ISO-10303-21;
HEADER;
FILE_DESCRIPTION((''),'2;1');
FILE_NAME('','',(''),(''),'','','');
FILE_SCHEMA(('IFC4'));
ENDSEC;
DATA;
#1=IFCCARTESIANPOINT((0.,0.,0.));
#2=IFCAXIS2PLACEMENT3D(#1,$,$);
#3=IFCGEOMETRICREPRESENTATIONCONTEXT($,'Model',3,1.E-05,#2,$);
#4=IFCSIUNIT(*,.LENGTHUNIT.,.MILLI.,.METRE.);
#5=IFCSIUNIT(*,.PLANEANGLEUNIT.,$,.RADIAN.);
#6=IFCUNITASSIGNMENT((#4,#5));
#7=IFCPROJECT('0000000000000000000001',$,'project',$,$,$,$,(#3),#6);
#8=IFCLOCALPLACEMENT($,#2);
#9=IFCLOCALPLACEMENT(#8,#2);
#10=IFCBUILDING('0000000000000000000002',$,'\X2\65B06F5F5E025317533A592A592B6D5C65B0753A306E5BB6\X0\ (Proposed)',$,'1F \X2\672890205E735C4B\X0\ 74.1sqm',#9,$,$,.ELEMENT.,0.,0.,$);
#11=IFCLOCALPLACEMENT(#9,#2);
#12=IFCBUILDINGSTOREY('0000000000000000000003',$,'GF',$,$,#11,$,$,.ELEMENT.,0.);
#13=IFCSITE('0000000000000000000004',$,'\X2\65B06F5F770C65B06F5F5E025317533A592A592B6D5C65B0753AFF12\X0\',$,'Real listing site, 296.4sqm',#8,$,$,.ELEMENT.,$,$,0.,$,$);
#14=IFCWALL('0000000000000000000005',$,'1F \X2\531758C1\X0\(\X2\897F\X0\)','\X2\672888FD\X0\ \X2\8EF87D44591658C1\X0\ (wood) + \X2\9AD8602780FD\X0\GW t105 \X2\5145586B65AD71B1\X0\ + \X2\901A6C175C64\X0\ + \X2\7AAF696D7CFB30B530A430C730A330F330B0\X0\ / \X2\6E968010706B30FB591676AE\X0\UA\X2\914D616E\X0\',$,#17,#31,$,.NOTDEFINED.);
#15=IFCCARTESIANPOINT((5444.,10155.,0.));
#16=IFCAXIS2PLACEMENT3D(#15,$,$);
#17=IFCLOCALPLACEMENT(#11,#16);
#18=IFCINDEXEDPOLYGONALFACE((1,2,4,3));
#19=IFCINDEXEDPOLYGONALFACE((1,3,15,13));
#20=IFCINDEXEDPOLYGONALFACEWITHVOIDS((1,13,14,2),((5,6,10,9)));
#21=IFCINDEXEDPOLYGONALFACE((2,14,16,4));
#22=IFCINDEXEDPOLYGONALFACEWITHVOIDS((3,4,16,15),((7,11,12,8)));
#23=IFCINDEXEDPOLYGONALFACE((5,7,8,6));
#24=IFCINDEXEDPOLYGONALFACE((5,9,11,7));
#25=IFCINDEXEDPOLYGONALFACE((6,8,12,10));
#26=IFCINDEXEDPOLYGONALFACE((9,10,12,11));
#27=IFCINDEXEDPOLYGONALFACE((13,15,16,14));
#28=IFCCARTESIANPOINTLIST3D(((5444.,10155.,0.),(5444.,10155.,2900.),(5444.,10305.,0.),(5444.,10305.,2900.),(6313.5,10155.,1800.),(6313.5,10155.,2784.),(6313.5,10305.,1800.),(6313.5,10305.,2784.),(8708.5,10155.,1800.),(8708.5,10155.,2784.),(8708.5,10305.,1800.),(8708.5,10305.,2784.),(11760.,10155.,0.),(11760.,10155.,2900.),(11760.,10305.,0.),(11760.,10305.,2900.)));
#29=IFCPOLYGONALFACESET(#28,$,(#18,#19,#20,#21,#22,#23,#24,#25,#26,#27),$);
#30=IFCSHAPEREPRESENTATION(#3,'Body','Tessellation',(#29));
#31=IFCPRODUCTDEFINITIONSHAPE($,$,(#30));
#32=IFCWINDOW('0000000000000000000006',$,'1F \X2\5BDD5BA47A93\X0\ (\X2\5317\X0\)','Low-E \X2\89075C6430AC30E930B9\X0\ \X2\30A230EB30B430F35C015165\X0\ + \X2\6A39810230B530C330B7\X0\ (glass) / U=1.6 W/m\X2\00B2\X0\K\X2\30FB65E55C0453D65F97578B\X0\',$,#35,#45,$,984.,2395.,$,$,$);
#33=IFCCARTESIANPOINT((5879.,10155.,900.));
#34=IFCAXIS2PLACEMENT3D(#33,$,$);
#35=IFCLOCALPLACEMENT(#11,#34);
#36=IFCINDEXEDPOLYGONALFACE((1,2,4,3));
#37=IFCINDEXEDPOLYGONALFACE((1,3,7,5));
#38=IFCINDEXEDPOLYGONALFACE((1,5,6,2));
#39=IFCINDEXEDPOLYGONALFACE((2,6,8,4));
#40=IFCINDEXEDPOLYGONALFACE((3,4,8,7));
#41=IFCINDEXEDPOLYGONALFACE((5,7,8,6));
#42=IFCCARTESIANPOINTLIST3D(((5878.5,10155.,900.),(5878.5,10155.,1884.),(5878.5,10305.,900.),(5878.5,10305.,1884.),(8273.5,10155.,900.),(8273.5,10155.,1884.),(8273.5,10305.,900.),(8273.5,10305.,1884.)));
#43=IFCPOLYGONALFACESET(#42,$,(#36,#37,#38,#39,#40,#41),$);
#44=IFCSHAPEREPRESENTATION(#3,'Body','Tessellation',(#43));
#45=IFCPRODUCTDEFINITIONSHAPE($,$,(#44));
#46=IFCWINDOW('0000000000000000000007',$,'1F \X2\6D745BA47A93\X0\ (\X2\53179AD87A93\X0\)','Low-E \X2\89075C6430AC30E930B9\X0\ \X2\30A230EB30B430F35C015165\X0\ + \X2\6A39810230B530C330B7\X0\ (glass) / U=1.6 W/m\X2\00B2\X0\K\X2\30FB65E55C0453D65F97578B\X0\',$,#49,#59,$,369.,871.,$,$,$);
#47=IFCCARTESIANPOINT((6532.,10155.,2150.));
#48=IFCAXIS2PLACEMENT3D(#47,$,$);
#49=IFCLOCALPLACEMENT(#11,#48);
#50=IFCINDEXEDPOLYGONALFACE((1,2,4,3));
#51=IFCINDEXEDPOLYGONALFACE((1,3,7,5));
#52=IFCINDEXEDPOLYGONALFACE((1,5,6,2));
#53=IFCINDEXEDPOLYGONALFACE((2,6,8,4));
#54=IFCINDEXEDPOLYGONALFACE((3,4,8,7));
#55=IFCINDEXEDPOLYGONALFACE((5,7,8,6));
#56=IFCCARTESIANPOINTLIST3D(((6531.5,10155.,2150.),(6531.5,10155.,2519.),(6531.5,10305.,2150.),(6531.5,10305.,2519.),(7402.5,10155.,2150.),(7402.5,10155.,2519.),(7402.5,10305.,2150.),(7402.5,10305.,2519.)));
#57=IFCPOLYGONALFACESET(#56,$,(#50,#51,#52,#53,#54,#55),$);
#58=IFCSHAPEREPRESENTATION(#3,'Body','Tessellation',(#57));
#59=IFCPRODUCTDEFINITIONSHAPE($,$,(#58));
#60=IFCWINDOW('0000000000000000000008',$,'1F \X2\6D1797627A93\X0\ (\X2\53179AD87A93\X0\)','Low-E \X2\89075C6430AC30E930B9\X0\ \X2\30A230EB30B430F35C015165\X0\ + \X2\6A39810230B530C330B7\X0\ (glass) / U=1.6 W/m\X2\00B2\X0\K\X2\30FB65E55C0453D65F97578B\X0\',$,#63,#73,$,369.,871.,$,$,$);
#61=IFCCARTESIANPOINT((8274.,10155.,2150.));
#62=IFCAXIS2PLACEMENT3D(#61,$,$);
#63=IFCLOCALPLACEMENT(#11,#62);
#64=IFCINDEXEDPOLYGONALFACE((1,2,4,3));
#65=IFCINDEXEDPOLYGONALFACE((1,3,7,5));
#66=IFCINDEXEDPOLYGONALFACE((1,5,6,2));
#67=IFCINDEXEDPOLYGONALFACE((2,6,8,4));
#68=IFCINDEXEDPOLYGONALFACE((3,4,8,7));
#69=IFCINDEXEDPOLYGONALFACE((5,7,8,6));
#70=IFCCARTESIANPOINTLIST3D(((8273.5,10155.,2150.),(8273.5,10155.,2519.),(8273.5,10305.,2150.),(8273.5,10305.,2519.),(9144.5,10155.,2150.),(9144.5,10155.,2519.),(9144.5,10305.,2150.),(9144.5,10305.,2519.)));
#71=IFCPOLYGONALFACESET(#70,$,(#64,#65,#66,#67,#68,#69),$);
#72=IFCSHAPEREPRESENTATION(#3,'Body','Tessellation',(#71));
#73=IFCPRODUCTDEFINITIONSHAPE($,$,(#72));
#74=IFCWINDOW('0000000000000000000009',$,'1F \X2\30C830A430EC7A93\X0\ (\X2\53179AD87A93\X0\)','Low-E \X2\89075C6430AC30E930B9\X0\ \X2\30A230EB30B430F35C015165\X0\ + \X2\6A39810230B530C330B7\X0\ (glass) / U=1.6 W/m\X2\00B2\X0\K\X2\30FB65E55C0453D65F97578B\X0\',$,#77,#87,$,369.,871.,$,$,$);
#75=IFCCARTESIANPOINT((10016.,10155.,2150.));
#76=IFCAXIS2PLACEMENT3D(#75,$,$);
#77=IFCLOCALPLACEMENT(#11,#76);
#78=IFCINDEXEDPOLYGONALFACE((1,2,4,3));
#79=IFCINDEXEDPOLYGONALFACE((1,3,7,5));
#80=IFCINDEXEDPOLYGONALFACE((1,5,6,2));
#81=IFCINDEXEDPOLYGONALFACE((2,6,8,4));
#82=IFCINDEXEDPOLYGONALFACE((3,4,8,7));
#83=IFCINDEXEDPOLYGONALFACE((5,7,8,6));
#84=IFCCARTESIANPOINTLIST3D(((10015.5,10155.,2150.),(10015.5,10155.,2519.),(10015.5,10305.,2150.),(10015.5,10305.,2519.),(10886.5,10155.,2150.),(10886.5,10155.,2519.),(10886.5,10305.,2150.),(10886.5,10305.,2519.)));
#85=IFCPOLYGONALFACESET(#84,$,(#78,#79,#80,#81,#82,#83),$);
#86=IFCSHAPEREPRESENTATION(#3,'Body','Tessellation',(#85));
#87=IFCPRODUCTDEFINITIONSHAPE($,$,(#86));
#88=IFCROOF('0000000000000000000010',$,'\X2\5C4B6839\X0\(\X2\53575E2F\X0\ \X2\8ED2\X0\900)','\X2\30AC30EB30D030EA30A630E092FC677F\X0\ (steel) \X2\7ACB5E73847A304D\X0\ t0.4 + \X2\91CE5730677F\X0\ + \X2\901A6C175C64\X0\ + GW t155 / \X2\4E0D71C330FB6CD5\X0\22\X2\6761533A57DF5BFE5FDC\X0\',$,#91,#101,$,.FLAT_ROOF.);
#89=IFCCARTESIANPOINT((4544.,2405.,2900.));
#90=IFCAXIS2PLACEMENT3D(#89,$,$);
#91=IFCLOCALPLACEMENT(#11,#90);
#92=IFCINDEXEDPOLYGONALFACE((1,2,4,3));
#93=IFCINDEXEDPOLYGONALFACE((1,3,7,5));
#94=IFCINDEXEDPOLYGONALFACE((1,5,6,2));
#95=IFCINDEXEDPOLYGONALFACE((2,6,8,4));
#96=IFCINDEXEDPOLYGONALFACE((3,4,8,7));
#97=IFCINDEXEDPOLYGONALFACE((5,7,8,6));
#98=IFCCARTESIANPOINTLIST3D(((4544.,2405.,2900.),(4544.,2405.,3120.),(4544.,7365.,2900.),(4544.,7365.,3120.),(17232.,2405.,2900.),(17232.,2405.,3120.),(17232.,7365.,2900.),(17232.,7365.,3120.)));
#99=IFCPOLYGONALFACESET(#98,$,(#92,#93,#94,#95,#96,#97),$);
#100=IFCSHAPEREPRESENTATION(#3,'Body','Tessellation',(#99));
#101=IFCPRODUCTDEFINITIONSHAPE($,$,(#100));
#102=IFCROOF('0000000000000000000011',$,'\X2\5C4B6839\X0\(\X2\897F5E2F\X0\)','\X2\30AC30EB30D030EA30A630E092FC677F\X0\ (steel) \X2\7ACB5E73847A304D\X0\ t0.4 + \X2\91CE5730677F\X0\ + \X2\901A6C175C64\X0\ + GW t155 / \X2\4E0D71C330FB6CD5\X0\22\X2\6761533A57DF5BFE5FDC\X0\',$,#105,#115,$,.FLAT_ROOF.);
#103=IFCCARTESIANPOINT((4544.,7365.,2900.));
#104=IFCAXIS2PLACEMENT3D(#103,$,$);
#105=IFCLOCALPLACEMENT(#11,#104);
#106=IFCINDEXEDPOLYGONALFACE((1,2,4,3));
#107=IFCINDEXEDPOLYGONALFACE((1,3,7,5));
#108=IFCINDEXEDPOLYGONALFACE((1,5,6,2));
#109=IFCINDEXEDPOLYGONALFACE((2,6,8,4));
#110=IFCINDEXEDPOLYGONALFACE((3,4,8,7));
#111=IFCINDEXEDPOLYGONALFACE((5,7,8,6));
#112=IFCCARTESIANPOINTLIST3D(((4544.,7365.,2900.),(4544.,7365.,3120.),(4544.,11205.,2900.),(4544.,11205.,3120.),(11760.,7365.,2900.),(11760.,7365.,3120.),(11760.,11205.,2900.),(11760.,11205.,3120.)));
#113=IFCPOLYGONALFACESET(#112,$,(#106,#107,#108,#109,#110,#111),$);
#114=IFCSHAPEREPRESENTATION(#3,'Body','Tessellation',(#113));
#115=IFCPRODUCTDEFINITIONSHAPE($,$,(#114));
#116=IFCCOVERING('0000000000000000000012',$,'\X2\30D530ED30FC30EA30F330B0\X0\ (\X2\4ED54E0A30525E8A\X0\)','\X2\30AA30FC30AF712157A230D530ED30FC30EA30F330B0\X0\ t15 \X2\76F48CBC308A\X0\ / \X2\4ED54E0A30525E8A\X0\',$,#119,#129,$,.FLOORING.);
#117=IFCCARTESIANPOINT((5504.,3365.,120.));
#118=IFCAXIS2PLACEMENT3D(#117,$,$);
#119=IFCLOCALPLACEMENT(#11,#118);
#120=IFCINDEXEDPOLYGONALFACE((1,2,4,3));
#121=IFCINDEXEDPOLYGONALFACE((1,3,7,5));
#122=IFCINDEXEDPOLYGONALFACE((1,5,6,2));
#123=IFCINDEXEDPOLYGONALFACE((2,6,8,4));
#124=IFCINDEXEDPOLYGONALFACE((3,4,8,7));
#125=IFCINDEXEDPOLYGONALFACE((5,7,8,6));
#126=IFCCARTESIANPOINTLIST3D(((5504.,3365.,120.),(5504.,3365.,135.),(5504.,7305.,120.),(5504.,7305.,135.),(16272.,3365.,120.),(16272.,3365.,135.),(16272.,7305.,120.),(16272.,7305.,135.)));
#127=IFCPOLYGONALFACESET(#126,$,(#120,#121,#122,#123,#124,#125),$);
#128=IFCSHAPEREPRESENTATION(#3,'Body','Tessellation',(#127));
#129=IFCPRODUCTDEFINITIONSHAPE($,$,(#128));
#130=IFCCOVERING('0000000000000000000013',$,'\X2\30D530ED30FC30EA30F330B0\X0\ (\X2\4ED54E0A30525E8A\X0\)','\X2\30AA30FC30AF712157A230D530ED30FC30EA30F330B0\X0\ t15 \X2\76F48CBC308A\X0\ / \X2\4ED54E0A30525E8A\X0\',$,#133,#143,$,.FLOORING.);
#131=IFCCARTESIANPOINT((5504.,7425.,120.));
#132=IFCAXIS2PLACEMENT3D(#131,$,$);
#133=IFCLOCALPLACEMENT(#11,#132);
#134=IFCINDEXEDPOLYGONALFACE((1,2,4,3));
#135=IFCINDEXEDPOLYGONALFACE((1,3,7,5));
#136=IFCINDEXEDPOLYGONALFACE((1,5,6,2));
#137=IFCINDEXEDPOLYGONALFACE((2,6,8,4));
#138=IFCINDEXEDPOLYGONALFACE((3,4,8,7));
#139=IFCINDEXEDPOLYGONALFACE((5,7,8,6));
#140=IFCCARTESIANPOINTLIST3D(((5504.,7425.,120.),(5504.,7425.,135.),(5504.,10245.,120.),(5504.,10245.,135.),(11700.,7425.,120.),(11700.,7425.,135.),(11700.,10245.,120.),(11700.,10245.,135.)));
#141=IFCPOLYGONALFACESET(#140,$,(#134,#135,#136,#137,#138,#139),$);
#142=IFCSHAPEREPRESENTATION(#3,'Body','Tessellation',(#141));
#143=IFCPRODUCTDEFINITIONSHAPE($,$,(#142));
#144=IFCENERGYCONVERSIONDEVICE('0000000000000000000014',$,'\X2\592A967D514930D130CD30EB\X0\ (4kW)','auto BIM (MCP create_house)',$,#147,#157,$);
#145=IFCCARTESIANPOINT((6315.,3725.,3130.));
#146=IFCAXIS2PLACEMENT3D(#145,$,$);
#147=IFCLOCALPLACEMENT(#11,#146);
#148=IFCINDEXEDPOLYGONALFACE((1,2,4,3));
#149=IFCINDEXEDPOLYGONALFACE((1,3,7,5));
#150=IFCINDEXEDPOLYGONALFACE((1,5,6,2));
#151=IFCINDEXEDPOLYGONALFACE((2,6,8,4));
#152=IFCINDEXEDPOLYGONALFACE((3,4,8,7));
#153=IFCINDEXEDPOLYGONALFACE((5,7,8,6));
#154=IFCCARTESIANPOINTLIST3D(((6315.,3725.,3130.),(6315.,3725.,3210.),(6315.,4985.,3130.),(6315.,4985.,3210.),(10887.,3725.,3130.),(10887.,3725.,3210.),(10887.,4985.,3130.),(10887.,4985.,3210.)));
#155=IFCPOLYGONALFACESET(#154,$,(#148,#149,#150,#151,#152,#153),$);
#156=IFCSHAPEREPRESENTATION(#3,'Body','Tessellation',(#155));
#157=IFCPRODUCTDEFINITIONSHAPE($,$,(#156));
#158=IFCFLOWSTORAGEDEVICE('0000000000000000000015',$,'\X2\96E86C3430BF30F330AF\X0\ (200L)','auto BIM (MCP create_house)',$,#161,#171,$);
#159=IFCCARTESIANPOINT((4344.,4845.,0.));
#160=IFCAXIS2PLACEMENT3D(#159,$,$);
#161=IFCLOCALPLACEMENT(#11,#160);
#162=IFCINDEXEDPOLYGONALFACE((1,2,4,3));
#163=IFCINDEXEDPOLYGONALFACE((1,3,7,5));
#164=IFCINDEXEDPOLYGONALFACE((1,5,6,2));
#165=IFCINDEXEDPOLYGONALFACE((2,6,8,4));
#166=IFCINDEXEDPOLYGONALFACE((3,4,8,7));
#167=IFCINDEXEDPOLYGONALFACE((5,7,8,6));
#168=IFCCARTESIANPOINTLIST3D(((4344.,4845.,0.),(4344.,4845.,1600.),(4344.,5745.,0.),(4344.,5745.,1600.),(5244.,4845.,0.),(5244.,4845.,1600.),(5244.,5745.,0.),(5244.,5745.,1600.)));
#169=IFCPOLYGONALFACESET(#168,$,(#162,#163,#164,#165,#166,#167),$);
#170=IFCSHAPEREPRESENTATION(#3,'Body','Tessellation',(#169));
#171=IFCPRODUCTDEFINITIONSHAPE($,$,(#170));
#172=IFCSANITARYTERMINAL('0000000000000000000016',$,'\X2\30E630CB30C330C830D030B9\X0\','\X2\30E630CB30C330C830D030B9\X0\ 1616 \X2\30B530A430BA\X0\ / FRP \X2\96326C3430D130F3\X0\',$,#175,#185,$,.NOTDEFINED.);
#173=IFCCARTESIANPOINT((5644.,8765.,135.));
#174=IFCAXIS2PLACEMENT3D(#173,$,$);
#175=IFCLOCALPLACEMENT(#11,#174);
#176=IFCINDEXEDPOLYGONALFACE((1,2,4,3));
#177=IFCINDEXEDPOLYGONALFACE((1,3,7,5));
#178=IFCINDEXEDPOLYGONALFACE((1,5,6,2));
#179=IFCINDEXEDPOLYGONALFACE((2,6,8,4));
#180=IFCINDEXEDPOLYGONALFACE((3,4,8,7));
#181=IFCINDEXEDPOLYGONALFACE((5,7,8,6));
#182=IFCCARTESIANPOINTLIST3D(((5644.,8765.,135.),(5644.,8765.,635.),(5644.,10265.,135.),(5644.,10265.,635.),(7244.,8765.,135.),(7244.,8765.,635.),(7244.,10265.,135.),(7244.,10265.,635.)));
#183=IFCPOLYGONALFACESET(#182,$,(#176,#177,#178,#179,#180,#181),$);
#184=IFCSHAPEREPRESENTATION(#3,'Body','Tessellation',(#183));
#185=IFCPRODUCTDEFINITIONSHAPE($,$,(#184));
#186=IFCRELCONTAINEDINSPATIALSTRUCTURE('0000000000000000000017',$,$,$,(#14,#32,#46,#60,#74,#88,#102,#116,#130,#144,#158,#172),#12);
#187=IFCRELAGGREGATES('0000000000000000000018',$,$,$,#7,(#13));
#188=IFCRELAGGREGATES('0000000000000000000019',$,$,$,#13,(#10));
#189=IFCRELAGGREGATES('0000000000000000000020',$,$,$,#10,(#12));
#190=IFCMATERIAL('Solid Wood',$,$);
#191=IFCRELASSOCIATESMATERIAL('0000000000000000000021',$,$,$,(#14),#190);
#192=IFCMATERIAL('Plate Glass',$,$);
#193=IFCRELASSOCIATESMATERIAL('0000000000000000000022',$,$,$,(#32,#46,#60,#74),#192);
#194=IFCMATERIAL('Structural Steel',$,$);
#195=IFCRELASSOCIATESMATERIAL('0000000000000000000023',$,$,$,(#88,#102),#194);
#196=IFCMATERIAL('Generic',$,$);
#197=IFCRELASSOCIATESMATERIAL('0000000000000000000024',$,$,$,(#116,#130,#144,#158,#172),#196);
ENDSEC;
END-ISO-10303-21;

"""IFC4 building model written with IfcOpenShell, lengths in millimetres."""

from ifc_helpers import new_model, si_unit, frame, frame_2d, origin, place, context, project, spatial, rectangle, extrude, material, element, fill, save


model = new_model("IFC4")

# Units and contexts
model_context = context("Model", 3, precision=1e-05, world=origin())
ifc_project = project(units=[si_unit("LENGTHUNIT", "METRE", prefix="MILLI"), si_unit("PLANEANGLEUNIT", "RADIAN")], contexts=[model_context])

# Site, building, storey
site_placement = place(None, origin())
site = spatial("IfcSite", under=ifc_project, at=site_placement, Name="新潟県新潟市北区太夫浜新町２", ObjectType="Real listing site, 296.4sqm", CompositionType="ELEMENT", RefElevation=0.0)
building_placement = place(site_placement, origin())
building = spatial("IfcBuilding", under=site, at=building_placement, Name="新潟市北区太夫浜新町の家 (Proposed)", ObjectType="1F 木造平屋 74.1sqm", CompositionType="ELEMENT", ElevationOfRefHeight=0.0, ElevationOfTerrain=0.0)
storey_placement = place(building_placement, origin())
storey = spatial("IfcBuildingStorey", under=building, at=storey_placement, Name="GF", CompositionType="ELEMENT", Elevation=0.0)

# Shared definitions
ifc_material_1 = material(Name="Solid Wood")

# Shared definitions
ifc_material_2 = material(Name="Plate Glass")

# Wall, openings, windows
wall_1_placement = place(storey_placement, frame((5444.0, 10155.0, 0.0)))
wall_1 = element("IfcWall", 1, at=wall_1_placement, inside=storey, material=ifc_material_1, Name="1F 北壁(西)", Description="木製 軸組外壁 (wood) + 高性能GW t105 充填断熱 + 通気層 + 窯業系サイディング / 準耐火・外皮UA配慮", PredefinedType="NOTDEFINED", context=model_context, shape_type="SweptSolid", body=[
    extrude(rectangle(XDim=6316.0, YDim=150.0, at=frame_2d((3158.0, 75.0))), frame((5444.0, 10155.0, 0.0)), (0.0, 0.0, 1.0), 2900.0),
])
opening_1_placement = place(storey_placement, frame((5879.0, 10155.0, 900.0)))
opening_1 = element("IfcOpeningElement", 2, at=opening_1_placement, cuts=wall_1, PredefinedType="NOTDEFINED", context=model_context, shape_type="SweptSolid", body=[
    extrude(rectangle(XDim=2395.0, YDim=150.0, at=frame_2d((1197.0, 75.0))), frame((5879.0, 10155.0, 900.0)), (0.0, 0.0, 1.0), 984.0),
])
opening_2_placement = place(storey_placement, frame((6532.0, 10155.0, 2150.0)))
opening_2 = element("IfcOpeningElement", 3, at=opening_2_placement, cuts=wall_1, PredefinedType="NOTDEFINED", context=model_context, shape_type="SweptSolid", body=[
    extrude(rectangle(XDim=871.0, YDim=150.0, at=frame_2d((435.0, 75.0))), frame((6532.0, 10155.0, 2150.0)), (0.0, 0.0, 1.0), 369.0),
])
opening_3_placement = place(storey_placement, frame((8274.0, 10155.0, 2150.0)))
opening_3 = element("IfcOpeningElement", 4, at=opening_3_placement, cuts=wall_1, PredefinedType="NOTDEFINED", context=model_context, shape_type="SweptSolid", body=[
    extrude(rectangle(XDim=871.0, YDim=150.0, at=frame_2d((435.0, 75.0))), frame((8274.0, 10155.0, 2150.0)), (0.0, 0.0, 1.0), 369.0),
])
opening_4_placement = place(storey_placement, frame((10016.0, 10155.0, 2150.0)))
opening_4 = element("IfcOpeningElement", 5, at=opening_4_placement, cuts=wall_1, PredefinedType="NOTDEFINED", context=model_context, shape_type="SweptSolid", body=[
    extrude(rectangle(XDim=871.0, YDim=150.0, at=frame_2d((435.0, 75.0))), frame((10016.0, 10155.0, 2150.0)), (0.0, 0.0, 1.0), 369.0),
])
window_1_placement = place(storey_placement, frame((5879.0, 10155.0, 900.0)))
window_1 = element("IfcWindow", 6, at=window_1_placement, inside=storey, material=ifc_material_2, Name="1F 寝室窓 (北)", Description="Low-E 複層ガラス アルゴン封入 + 樹脂サッシ (glass) / U=1.6 W/m²K・日射取得型", OverallHeight=984.0, OverallWidth=2395.0, context=model_context, shape_type="SweptSolid", body=[
    extrude(rectangle(XDim=2395.0, YDim=150.0, at=frame_2d((1197.0, 75.0))), frame((5879.0, 10155.0, 900.0)), (0.0, 0.0, 1.0), 984.0),
])
fill(opening_1, window_1)
window_2_placement = place(storey_placement, frame((6532.0, 10155.0, 2150.0)))
window_2 = element("IfcWindow", 7, at=window_2_placement, inside=storey, material=ifc_material_2, Name="1F 浴室窓 (北高窓)", Description="Low-E 複層ガラス アルゴン封入 + 樹脂サッシ (glass) / U=1.6 W/m²K・日射取得型", OverallHeight=369.0, OverallWidth=871.0, context=model_context, shape_type="SweptSolid", body=[
    extrude(rectangle(XDim=871.0, YDim=150.0, at=frame_2d((435.0, 75.0))), frame((6532.0, 10155.0, 2150.0)), (0.0, 0.0, 1.0), 369.0),
])
fill(opening_2, window_2)
window_3_placement = place(storey_placement, frame((8274.0, 10155.0, 2150.0)))
window_3 = element("IfcWindow", 8, at=window_3_placement, inside=storey, material=ifc_material_2, Name="1F 洗面窓 (北高窓)", Description="Low-E 複層ガラス アルゴン封入 + 樹脂サッシ (glass) / U=1.6 W/m²K・日射取得型", OverallHeight=369.0, OverallWidth=871.0, context=model_context, shape_type="SweptSolid", body=[
    extrude(rectangle(XDim=871.0, YDim=150.0, at=frame_2d((435.0, 75.0))), frame((8274.0, 10155.0, 2150.0)), (0.0, 0.0, 1.0), 369.0),
])
fill(opening_3, window_3)
window_4_placement = place(storey_placement, frame((10016.0, 10155.0, 2150.0)))
window_4 = element("IfcWindow", 9, at=window_4_placement, inside=storey, material=ifc_material_2, Name="1F トイレ窓 (北高窓)", Description="Low-E 複層ガラス アルゴン封入 + 樹脂サッシ (glass) / U=1.6 W/m²K・日射取得型", OverallHeight=369.0, OverallWidth=871.0, context=model_context, shape_type="SweptSolid", body=[
    extrude(rectangle(XDim=871.0, YDim=150.0, at=frame_2d((435.0, 75.0))), frame((10016.0, 10155.0, 2150.0)), (0.0, 0.0, 1.0), 369.0),
])
fill(opening_4, window_4)

# Roofs
ifc_material_3 = material(Name="Structural Steel")
roof_1_placement = place(storey_placement, frame((4544.0, 2405.0, 2900.0)))
element("IfcRoof", 10, at=roof_1_placement, inside=storey, material=ifc_material_3, Name="屋根(南帯 軒900)", Description="ガルバリウム鋼板 (steel) 立平葺き t0.4 + 野地板 + 通気層 + GW t155 / 不燃・法22条区域対応", PredefinedType="FLAT_ROOF", context=model_context, shape_type="SweptSolid", body=[
    extrude(rectangle(XDim=12688.0, YDim=4960.0, at=frame_2d((6344.0, 2480.0))), frame((4544.0, 2405.0, 2900.0)), (0.0, 0.0, 1.0), 220.0),
])
roof_2_placement = place(storey_placement, frame((4544.0, 7365.0, 2900.0)))
element("IfcRoof", 11, at=roof_2_placement, inside=storey, material=ifc_material_3, Name="屋根(西帯)", Description="ガルバリウム鋼板 (steel) 立平葺き t0.4 + 野地板 + 通気層 + GW t155 / 不燃・法22条区域対応", PredefinedType="FLAT_ROOF", context=model_context, shape_type="SweptSolid", body=[
    extrude(rectangle(XDim=7216.0, YDim=3840.0, at=frame_2d((3608.0, 1920.0))), frame((4544.0, 7365.0, 2900.0)), (0.0, 0.0, 1.0), 220.0),
])

# Coverings
ifc_material_4 = material(Name="Generic")
covering_1_placement = place(storey_placement, frame((5504.0, 3365.0, 120.0)))
element("IfcCovering", 12, at=covering_1_placement, inside=storey, material=ifc_material_4, Name="フローリング (仕上げ床)", Description="オーク無垢フローリング t15 直貼り / 仕上げ床", PredefinedType="FLOORING", context=model_context, shape_type="SweptSolid", body=[
    extrude(rectangle(XDim=10768.0, YDim=3940.0, at=frame_2d((5384.0, 1970.0))), frame((5504.0, 3365.0, 120.0)), (0.0, 0.0, 1.0), 15.0),
])
covering_2_placement = place(storey_placement, frame((5504.0, 7425.0, 120.0)))
element("IfcCovering", 13, at=covering_2_placement, inside=storey, material=ifc_material_4, Name="フローリング (仕上げ床)", Description="オーク無垢フローリング t15 直貼り / 仕上げ床", PredefinedType="FLOORING", context=model_context, shape_type="SweptSolid", body=[
    extrude(rectangle(XDim=6196.0, YDim=2820.0, at=frame_2d((3098.0, 1410.0))), frame((5504.0, 7425.0, 120.0)), (0.0, 0.0, 1.0), 15.0),
])

# Energy conversion device
energy_conversion_device_placement = place(storey_placement, frame((6315.0, 3725.0, 3130.0)))
element("IfcEnergyConversionDevice", 14, at=energy_conversion_device_placement, inside=storey, material=ifc_material_4, Name="太陽光パネル (4kW)", Description="auto BIM (MCP create_house)", context=model_context, shape_type="SweptSolid", body=[
    extrude(rectangle(XDim=4572.0, YDim=1260.0, at=frame_2d((2286.0, 630.0))), frame((6315.0, 3725.0, 3130.0)), (0.0, 0.0, 1.0), 80.0),
])

# Flow storage device
flow_storage_device_placement = place(storey_placement, frame((4344.0, 4845.0, 0.0)))
element("IfcFlowStorageDevice", 15, at=flow_storage_device_placement, inside=storey, material=ifc_material_4, Name="雨水タンク (200L)", Description="auto BIM (MCP create_house)", context=model_context, shape_type="SweptSolid", body=[
    extrude(rectangle(XDim=900.0, YDim=900.0, at=frame_2d((450.0, 450.0))), frame((4344.0, 4845.0, 0.0)), (0.0, 0.0, 1.0), 1600.0),
])

# Sanitary terminal
sanitary_terminal_placement = place(storey_placement, frame((5644.0, 8765.0, 135.0)))
element("IfcSanitaryTerminal", 16, at=sanitary_terminal_placement, inside=storey, material=ifc_material_4, Name="ユニットバス", Description="ユニットバス 1616 サイズ / FRP 防水パン", PredefinedType="NOTDEFINED", context=model_context, shape_type="SweptSolid", body=[
    extrude(rectangle(XDim=1600.0, YDim=1500.0, at=frame_2d((800.0, 750.0))), frame((5644.0, 8765.0, 135.0)), (0.0, 0.0, 1.0), 500.0),
])

save(model, "model.ifc")
